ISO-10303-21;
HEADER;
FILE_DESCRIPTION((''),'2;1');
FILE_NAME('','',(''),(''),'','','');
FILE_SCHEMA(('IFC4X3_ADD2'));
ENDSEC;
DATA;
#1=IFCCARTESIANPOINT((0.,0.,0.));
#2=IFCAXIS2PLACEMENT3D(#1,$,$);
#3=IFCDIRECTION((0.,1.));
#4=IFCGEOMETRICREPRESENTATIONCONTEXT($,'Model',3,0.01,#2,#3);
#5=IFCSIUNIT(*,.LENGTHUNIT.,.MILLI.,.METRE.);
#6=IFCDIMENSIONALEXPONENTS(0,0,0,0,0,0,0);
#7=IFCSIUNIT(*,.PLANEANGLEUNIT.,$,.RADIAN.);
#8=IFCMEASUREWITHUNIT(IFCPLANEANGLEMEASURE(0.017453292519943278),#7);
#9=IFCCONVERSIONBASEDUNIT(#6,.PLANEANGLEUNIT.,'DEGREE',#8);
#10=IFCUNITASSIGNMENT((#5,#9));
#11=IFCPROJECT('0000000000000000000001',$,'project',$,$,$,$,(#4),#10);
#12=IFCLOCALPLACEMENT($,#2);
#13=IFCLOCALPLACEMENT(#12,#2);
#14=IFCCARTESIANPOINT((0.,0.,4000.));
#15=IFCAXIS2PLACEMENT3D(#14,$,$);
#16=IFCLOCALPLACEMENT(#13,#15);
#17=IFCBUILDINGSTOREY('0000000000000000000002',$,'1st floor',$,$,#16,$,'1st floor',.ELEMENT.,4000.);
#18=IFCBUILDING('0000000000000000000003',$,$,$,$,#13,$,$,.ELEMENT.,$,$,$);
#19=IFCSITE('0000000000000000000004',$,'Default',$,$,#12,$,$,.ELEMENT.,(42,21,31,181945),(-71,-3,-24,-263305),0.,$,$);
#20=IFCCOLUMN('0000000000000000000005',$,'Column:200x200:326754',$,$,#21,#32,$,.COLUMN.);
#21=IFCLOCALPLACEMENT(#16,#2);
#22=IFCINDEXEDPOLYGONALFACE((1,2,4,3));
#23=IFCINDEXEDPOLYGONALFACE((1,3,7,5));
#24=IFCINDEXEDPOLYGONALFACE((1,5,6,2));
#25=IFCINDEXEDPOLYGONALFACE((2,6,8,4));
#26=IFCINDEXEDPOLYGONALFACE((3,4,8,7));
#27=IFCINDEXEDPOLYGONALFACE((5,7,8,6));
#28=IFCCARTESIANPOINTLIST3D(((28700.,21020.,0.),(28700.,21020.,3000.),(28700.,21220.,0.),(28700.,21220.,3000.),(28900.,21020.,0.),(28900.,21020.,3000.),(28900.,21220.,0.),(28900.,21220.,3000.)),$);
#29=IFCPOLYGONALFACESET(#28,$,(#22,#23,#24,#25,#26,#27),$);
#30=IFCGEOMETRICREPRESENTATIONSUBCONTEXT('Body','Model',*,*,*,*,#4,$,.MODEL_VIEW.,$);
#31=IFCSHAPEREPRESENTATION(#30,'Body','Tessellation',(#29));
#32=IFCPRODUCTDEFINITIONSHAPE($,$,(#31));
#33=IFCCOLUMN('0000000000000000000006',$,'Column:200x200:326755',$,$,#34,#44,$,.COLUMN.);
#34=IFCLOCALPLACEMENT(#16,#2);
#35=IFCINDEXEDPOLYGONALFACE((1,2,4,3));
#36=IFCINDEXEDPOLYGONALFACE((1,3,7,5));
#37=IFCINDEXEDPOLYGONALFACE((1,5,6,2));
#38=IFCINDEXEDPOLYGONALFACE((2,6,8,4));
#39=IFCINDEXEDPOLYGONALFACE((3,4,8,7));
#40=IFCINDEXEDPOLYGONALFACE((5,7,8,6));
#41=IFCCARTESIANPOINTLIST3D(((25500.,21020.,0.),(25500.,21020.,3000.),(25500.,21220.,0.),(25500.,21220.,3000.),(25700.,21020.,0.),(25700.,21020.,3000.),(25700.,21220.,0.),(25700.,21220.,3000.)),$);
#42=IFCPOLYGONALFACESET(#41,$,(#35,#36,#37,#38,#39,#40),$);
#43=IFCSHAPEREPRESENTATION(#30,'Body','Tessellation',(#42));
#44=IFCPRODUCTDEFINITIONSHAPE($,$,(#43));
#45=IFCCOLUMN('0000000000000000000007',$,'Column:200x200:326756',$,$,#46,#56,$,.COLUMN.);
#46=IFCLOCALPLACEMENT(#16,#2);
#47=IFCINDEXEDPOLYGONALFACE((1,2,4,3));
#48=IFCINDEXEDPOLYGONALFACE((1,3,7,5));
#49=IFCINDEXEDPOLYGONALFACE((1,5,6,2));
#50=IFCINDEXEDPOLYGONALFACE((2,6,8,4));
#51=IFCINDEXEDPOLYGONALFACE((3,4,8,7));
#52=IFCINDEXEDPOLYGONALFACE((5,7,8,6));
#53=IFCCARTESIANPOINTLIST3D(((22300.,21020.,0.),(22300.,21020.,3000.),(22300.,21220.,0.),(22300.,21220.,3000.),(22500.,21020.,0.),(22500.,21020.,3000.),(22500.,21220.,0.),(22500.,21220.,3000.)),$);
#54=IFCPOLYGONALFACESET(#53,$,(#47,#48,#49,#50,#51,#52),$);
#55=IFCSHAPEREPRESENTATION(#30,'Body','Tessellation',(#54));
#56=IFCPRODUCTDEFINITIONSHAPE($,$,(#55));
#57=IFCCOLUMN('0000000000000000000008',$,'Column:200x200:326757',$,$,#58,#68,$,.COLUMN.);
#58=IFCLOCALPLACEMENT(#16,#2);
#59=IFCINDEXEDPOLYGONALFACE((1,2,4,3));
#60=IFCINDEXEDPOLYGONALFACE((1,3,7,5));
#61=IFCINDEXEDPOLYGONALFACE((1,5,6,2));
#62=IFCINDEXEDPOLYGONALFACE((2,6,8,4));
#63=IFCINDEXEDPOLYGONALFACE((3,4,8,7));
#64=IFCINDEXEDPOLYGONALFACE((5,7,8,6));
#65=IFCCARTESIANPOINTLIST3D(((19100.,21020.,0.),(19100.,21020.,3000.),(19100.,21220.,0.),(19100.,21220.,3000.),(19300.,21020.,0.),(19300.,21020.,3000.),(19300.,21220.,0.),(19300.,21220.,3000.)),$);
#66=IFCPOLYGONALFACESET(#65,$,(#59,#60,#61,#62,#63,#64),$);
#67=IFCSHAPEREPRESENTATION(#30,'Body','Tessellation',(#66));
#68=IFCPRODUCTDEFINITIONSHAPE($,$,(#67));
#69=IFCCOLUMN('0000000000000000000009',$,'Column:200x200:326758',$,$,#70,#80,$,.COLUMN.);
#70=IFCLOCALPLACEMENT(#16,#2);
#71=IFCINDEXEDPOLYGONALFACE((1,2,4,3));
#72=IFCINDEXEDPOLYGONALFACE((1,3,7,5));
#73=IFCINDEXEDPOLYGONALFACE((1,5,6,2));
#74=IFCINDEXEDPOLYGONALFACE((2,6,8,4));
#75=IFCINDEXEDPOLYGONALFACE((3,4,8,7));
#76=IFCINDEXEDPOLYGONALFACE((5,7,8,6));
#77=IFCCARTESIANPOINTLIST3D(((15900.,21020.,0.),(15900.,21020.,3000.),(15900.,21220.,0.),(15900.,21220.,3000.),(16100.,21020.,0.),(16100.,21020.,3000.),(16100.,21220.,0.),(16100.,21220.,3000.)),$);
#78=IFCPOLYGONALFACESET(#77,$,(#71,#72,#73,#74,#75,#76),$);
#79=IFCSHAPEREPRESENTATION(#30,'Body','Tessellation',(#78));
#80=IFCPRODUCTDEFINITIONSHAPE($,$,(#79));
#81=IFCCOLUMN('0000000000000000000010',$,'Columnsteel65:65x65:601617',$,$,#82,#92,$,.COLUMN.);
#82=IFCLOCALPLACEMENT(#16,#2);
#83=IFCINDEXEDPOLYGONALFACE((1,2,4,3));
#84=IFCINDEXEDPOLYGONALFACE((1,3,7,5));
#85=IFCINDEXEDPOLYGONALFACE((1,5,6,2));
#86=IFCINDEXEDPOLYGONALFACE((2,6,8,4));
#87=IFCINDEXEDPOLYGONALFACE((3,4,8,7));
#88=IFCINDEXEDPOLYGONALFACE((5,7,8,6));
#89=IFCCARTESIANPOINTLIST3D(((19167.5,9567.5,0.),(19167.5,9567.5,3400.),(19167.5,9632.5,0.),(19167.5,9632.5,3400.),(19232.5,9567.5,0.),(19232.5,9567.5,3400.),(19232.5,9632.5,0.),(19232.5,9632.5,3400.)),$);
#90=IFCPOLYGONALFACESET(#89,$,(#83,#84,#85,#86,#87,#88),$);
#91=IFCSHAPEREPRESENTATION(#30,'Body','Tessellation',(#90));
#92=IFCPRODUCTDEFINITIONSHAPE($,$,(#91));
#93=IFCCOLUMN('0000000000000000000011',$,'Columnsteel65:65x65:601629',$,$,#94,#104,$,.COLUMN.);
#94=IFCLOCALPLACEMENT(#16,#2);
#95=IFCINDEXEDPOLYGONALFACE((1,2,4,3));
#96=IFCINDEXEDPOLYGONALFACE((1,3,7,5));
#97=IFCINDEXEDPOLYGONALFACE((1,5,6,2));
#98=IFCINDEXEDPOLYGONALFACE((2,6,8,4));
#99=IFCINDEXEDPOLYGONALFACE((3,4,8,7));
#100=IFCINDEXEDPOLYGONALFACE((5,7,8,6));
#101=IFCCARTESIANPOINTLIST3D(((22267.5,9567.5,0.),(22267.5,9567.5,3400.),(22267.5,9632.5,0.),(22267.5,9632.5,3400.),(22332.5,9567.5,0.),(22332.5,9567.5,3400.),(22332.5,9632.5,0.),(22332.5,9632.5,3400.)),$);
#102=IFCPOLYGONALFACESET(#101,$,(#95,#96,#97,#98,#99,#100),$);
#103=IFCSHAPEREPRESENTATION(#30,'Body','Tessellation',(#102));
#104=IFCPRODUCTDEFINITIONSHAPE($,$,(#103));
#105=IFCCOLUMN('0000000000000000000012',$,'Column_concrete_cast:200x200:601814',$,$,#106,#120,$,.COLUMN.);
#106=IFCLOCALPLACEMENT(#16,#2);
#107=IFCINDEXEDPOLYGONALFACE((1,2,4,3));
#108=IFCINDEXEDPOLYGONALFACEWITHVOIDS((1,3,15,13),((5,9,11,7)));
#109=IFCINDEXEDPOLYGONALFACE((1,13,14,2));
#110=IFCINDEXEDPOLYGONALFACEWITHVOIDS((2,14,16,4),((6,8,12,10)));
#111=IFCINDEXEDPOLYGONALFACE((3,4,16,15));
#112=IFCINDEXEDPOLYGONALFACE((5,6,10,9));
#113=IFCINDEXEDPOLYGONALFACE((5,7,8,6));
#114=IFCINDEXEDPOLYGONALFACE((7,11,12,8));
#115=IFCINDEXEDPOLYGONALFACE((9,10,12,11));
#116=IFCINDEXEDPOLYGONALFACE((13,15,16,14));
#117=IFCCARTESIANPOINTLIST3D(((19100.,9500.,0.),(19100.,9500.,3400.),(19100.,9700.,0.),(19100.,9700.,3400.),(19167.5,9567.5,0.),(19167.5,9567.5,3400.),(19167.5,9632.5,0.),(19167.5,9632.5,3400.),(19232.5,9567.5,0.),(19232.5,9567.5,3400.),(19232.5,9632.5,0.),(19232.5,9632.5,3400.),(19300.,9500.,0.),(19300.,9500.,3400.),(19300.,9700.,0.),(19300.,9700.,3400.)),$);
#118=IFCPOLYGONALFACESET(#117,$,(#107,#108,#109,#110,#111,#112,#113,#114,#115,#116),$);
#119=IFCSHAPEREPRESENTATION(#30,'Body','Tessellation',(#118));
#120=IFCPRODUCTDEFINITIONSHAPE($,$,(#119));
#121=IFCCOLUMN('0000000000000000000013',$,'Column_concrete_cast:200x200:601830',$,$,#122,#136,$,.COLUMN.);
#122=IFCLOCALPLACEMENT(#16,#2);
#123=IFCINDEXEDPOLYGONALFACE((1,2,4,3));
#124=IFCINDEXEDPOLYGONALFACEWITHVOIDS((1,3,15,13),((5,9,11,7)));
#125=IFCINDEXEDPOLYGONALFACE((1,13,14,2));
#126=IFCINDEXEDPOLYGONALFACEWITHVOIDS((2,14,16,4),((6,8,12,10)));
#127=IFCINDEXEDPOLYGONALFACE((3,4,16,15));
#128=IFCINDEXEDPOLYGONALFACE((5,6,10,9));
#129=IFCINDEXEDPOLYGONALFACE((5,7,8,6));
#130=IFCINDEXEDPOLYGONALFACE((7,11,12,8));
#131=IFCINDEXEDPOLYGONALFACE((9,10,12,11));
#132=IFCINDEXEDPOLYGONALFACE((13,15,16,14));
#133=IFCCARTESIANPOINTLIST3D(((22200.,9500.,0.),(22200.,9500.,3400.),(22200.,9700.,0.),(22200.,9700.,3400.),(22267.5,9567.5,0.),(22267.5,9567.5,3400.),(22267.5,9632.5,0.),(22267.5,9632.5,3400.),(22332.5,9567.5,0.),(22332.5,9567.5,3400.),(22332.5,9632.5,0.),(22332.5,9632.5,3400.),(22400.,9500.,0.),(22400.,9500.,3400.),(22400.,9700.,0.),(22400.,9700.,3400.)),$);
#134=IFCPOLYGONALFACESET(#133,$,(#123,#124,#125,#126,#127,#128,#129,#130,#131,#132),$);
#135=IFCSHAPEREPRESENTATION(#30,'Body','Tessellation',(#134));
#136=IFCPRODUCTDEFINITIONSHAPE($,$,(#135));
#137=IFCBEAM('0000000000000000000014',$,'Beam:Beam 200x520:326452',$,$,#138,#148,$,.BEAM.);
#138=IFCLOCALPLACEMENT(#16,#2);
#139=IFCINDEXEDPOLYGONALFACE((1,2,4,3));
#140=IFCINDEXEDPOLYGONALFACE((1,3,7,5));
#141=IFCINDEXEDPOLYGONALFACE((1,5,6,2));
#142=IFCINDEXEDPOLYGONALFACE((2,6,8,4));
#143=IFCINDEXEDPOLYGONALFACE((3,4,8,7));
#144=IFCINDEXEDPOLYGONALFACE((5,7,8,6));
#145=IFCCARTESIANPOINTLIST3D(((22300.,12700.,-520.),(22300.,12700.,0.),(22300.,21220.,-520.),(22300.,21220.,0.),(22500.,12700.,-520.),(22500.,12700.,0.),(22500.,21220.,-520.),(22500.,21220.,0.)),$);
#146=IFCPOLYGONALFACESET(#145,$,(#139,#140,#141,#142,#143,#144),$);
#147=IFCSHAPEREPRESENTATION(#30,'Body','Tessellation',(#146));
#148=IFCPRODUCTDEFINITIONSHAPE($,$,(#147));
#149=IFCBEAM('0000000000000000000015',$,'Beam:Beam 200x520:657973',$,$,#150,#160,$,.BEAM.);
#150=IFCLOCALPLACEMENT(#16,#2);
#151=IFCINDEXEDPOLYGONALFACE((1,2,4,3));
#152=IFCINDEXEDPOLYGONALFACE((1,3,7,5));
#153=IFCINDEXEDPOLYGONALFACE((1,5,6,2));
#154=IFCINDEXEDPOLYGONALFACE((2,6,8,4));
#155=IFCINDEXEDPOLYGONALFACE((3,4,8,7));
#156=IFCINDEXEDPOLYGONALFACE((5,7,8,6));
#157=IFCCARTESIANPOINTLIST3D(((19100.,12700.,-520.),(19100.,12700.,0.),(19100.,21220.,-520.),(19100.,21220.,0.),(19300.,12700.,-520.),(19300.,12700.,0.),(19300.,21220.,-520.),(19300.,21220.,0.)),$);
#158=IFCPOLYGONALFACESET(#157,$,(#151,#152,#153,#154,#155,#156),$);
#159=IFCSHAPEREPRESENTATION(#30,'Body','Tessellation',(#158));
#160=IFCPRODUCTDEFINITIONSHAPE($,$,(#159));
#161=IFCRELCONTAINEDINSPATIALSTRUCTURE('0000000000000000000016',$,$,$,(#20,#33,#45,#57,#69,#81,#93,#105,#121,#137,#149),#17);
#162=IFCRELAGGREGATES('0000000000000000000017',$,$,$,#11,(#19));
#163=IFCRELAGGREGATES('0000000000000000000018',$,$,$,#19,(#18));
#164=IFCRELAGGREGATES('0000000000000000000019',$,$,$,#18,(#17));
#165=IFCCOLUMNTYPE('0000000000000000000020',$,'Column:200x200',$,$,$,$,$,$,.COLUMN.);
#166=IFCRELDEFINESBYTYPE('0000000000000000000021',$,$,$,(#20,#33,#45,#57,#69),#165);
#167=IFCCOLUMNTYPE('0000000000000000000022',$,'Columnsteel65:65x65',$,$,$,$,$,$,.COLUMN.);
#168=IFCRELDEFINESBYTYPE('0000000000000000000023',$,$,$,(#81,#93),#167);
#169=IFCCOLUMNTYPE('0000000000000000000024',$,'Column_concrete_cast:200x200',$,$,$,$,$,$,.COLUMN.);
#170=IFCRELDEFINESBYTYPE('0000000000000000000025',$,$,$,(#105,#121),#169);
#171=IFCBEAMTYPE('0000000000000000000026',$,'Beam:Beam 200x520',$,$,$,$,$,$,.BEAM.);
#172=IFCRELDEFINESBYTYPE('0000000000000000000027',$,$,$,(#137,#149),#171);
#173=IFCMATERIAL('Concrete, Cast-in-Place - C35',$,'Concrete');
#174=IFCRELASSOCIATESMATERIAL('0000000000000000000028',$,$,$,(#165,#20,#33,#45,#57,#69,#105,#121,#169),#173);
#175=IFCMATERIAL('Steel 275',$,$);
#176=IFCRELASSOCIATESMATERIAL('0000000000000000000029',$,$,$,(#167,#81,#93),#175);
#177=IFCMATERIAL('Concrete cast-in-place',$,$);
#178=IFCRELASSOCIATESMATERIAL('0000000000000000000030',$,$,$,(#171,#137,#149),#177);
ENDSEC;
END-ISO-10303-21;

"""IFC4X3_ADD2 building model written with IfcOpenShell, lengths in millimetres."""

from ifc_helpers import new_model, entity, si_unit, converted_unit, direction, frame, frame_2d, origin, origin_2d_with_axis, place, context, subcontext, project, spatial, polyline, rectangle, outline, extrude, source, transform, mapped, material, material_profile, profile_set, profile_usage, type_object, type_shapes, element, save


model = new_model("IFC4X3_ADD2")

# Units and contexts
model_context = context("Model", 3, precision=0.01, world=origin(), true_north=direction((0.0, 1.0)))
body_context = subcontext(model_context, "Body", "Model", "MODEL_VIEW")
ifc_project = project(units=[si_unit("LENGTHUNIT", "METRE", prefix="MILLI"), converted_unit("PLANEANGLEUNIT", "DEGREE", entity("IfcPlaneAngleMeasure", 0.017453292519943278), si_unit("PLANEANGLEUNIT", "RADIAN"), dimensions=[0, 0, 0, 0, 0, 0, 0])], contexts=[model_context])

# Site, building, storey
site_placement = place(None, origin())
site = spatial("IfcSite", under=ifc_project, at=site_placement, Name="Default", CompositionType="ELEMENT", RefLatitude=(42, 21, 31, 181945), RefLongitude=(-71, -3, -24, -263305), RefElevation=0.0)
building_placement = place(site_placement, origin())
building = spatial("IfcBuilding", under=site, at=building_placement, CompositionType="ELEMENT")
storey_placement = place(building_placement, frame((0.0, 0.0, 4000.0)))
storey = spatial("IfcBuildingStorey", under=building, at=storey_placement, Name="1st floor", LongName="1st floor", CompositionType="ELEMENT", Elevation=4000.0)

# Columns
ifc_material_1 = material(Name="Concrete, Cast-in-Place - C35", Category="Concrete")
ifc_material_profile_1 = material_profile(ifc_material_1, rectangle(XDim=200.0, YDim=200.0, at=frame_2d((0.0, 0.0), x_axis=(1.0, 0.0))), Name="200x200")
ifc_profile_set_1 = profile_set([ifc_material_profile_1], Name="200x200")
ifc_profile_usage_1 = profile_usage(ifc_profile_set_1)
column_type_1 = type_object("IfcColumnType", Name="Column:200x200", PredefinedType="COLUMN", material=ifc_profile_set_1)
shared_shape_1 = source(origin(), body_context, "Body", "SweptSolid", [
    extrude(rectangle(XDim=200.0, YDim=200.0, at=frame_2d((0.0, 0.0), x_axis=(1.0, 0.0))), frame((0.0, 0.0, 4000.0), z_axis=(0.0, 0.0, 1.0), x_axis=(-1.0, 0.0, 0.0)), (0.0, 0.0, 1.0), 3000.0),
])
type_shapes(column_type_1, [shared_shape_1])
for number, where, name in (
    (1, (28800.0, 21120.0, -4000.0), "Column:200x200:326754"),
    (2, (25600.0, 21120.0, -4000.0), "Column:200x200:326755"),
    (3, (22400.0, 21120.0, -4000.0), "Column:200x200:326756"),
    (4, (19200.0, 21120.0, -4000.0), "Column:200x200:326757"),
    (5, (16000.0, 21120.0, -4000.0), "Column:200x200:326758"),
):
    element("IfcColumn", number, at=place(storey_placement, frame(where)), inside=storey, type_object=column_type_1, material=ifc_profile_usage_1, Name=name, PredefinedType="COLUMN", context=body_context, shape_type="MappedRepresentation", body=[
        mapped(shared_shape_1, transform((0.0, 0.0, 0.0), scale=1.0)),
    ])
ifc_material_2 = material(Name="Steel 275")
ifc_material_profile_2 = material_profile(ifc_material_2, rectangle(XDim=65.0, YDim=65.0, at=frame_2d((0.0, 0.0), x_axis=(1.0, 0.0))), Name="65x65")
ifc_profile_set_2 = profile_set([ifc_material_profile_2], Name="65x65")
ifc_profile_usage_2 = profile_usage(ifc_profile_set_2)
column_type_2 = type_object("IfcColumnType", Name="Columnsteel65:65x65", PredefinedType="COLUMN", material=ifc_profile_set_2)
shared_shape_2 = source(origin(), body_context, "Body", "SweptSolid", [
    extrude(rectangle(XDim=65.0, YDim=65.0, at=frame_2d((0.0, 0.0), x_axis=(1.0, 0.0))), frame((0.0, 0.0, 4000.0), z_axis=(0.0, 0.0, 1.0), x_axis=(-1.0, 0.0, 0.0)), (0.0, 0.0, 1.0), 3400.0),
])
type_shapes(column_type_2, [shared_shape_2])
for number, where, name in (
    (6, (19200.0, 9600.0, -4000.0), "Columnsteel65:65x65:601617"),
    (7, (22300.0, 9600.0, -4000.0), "Columnsteel65:65x65:601629"),
):
    element("IfcColumn", number, at=place(storey_placement, frame(where)), inside=storey, type_object=column_type_2, material=ifc_profile_usage_2, Name=name, PredefinedType="COLUMN", context=body_context, shape_type="MappedRepresentation", body=[
        mapped(shared_shape_2, transform((0.0, 0.0, 0.0), scale=1.0)),
    ])
ifc_material_profile_3 = material_profile(ifc_material_1, outline(polyline([(-100.0, -100.0), (100.0, -100.0), (100.0, 100.0), (-100.0, 100.0), (-100.0, -100.0)]), holes=[polyline([(-32.5, 32.5), (32.5, 32.5), (32.5, -32.5), (-32.5, -32.5), (-32.5, 32.5)])]), Name="200x200")
ifc_profile_set_3 = profile_set([ifc_material_profile_3], Name="200x200")
column_type_3 = type_object("IfcColumnType", Name="Column_concrete_cast:200x200", PredefinedType="COLUMN", material=ifc_profile_set_3)
shared_shape_3 = source(origin(), body_context, "Body", "SweptSolid", [
    extrude(outline(polyline([(-100.0, -100.0), (100.0, -100.0), (100.0, 100.0), (-100.0, 100.0), (-100.0, -100.0)]), holes=[polyline([(-32.5, 32.5), (32.5, 32.5), (32.5, -32.5), (-32.5, -32.5), (-32.5, 32.5)])]), frame((0.0, 0.0, 4000.0), z_axis=(0.0, 0.0, 1.0), x_axis=(-1.0, 0.0, 0.0)), (0.0, 0.0, 1.0), 3400.0),
])
type_shapes(column_type_3, [shared_shape_3])
for number, where, name in (
    (8, (19200.0, 9600.0, -4000.0), "Column_concrete_cast:200x200:601814"),
    (9, (22300.0, 9600.0, -4000.0), "Column_concrete_cast:200x200:601830"),
):
    element("IfcColumn", number, at=place(storey_placement, frame(where)), inside=storey, type_object=column_type_3, material=ifc_profile_usage_1, Name=name, PredefinedType="COLUMN", context=body_context, shape_type="MappedRepresentation", body=[
        mapped(shared_shape_3, transform((0.0, 0.0, 0.0), scale=1.0)),
    ])

# Beams
ifc_material_3 = material(Name="Concrete cast-in-place")
ifc_material_profile_4 = material_profile(ifc_material_3, rectangle(XDim=8520.0, YDim=200.0, at=origin_2d_with_axis()), Name="Beam 200x520")
ifc_profile_set_4 = profile_set([ifc_material_profile_4], Name="Beam 200x520")
ifc_profile_usage_3 = profile_usage(ifc_profile_set_4, cardinal=8)
beam_type_1 = type_object("IfcBeamType", Name="Beam:Beam 200x520", PredefinedType="BEAM", material=ifc_profile_set_4)
shared_shape_4 = source(origin(), body_context, "Body", "SweptSolid", [
    extrude(rectangle(XDim=8520.0, YDim=200.0, at=origin_2d_with_axis()), frame((0.0, 0.0, -260.0), z_axis=(0.0, 0.0, 1.0), x_axis=(-1.0, 0.0, 0.0)), (0.0, 0.0, 1.0), 520.0),
])
type_shapes(beam_type_1, [shared_shape_4])
for number, where, z_axis, x_axis, name in (
    (10, (22400.0, 16960.0, -260.0), (0.0, 0.0, 1.0), (0.0, -1.0, 0.0), "Beam:Beam 200x520:326452"),
    (11, (19200.0, 16960.0, -260.0), (0.0, 0.0, 1.0), (0.0, -1.0, 0.0), "Beam:Beam 200x520:657973"),
):
    element("IfcBeam", number, at=place(storey_placement, frame(where, z_axis=z_axis, x_axis=x_axis)), inside=storey, type_object=beam_type_1, material=ifc_profile_usage_3, Name=name, PredefinedType="BEAM", context=body_context, shape_type="MappedRepresentation", body=[
        mapped(shared_shape_4, transform((0.0, 0.0, 0.0), scale=1.0)),
    ])

save(model, "model.ifc")
